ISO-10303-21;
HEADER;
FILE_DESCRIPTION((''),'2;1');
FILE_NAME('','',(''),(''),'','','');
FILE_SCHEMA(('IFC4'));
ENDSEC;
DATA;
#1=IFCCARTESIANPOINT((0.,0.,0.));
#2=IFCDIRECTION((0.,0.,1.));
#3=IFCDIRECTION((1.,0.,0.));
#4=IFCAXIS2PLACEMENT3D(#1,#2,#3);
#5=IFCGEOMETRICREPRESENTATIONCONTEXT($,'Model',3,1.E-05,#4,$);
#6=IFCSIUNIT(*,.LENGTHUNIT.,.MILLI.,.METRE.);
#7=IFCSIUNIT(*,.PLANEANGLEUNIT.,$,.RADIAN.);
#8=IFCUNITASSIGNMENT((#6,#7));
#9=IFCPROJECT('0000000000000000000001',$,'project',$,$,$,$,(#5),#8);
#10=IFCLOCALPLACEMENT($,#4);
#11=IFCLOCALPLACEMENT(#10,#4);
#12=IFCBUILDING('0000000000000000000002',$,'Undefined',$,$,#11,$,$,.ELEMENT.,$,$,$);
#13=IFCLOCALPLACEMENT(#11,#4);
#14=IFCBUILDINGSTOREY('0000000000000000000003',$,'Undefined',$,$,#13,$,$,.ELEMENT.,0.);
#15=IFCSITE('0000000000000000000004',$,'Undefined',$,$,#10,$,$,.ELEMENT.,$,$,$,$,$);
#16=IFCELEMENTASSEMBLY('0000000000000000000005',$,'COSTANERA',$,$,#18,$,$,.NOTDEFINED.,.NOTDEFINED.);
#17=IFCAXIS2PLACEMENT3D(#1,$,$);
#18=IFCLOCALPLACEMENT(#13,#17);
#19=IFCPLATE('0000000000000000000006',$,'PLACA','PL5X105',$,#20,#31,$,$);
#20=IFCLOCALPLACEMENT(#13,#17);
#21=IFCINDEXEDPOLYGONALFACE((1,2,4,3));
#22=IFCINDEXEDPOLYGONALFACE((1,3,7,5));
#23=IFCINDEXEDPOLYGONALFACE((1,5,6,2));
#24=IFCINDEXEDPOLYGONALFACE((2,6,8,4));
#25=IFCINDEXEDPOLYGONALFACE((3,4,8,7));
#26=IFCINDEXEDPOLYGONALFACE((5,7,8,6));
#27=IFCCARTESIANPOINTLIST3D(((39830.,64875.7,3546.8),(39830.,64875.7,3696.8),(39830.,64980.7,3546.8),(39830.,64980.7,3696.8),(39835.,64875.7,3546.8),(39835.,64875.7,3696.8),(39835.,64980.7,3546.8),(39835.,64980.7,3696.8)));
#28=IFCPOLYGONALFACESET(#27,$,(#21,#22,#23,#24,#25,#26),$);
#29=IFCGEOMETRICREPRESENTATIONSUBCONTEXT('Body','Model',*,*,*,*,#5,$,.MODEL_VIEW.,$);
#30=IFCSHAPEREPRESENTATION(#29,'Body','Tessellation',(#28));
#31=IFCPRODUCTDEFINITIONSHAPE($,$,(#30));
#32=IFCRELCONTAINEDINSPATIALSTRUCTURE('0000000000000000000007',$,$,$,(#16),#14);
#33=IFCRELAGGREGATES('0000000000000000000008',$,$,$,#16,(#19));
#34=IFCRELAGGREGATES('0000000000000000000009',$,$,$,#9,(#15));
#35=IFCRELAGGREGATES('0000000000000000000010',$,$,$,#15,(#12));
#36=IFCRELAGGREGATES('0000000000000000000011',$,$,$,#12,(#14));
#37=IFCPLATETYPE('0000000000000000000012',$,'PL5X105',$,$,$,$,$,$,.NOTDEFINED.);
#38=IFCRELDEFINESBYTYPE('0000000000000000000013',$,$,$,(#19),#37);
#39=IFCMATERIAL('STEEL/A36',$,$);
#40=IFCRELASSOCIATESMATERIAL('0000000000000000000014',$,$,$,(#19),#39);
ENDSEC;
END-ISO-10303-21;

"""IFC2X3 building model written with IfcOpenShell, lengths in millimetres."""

from ifc_helpers import new_model, si_unit, frame, origin_with_axes, place, context, subcontext, project, spatial, polyline, outline, extrude, material, type_object, element, aggregate, save


model = new_model("IFC2X3")

# Units and contexts
model_context = context("Model", 3, precision=1e-05, world=origin_with_axes())
body_context = subcontext(model_context, "Body", "Model", "MODEL_VIEW")
ifc_project = project(units=[si_unit("LENGTHUNIT", "METRE", prefix="MILLI"), si_unit("PLANEANGLEUNIT", "RADIAN")], contexts=[model_context])

# Site, building, storey
site_placement = place(None, origin_with_axes())
site = spatial("IfcSite", under=ifc_project, at=site_placement, Name="Undefined", CompositionType="ELEMENT")
building_placement = place(site_placement, origin_with_axes())
building = spatial("IfcBuilding", under=site, at=building_placement, Name="Undefined", CompositionType="ELEMENT")
storey_placement = place(building_placement, origin_with_axes())
storey = spatial("IfcBuildingStorey", under=building, at=storey_placement, Name="Undefined", CompositionType="ELEMENT", Elevation=0.0)

# Shared definitions
ifc_material_1 = material(Name="STEEL/A36")

# Element assembly
assembly_1_placement = place(storey_placement, origin_with_axes())
assembly_1 = element("IfcElementAssembly", 1, at=assembly_1_placement, inside=storey, Name="COSTANERA", AssemblyPlace="NOTDEFINED", PredefinedType="NOTDEFINED")

# Plate
plate_type_1 = type_object("IfcPlateType", Name="PL5X105", PredefinedType="NOTDEFINED")
plate_1_placement = place(assembly_1_placement, frame((39832.5, 64980.7, 3546.8), z_axis=(-1.0, 0.0, 0.0), x_axis=(0.0, -1.0, 0.0)))
plate_1 = element("IfcPlate", 2, at=plate_1_placement, type_object=plate_type_1, material=ifc_material_1, Name="PLACA", Description="PL5X105", context=body_context, shape_type="SweptSolid", body=[
    extrude(outline(polyline([(0.0, 0.0), (105.0, 0.0), (105.0, 150.0), (0.0, 150.0), (0.0, 0.0)])), frame((0.0, 0.0, -2.5), z_axis=(0.0, 0.0, 1.0), x_axis=(1.0, 0.0, 0.0)), (0.0, 0.0, 1.0), 5.0),
])

aggregate(assembly_1, [plate_1])

save(model, "model.ifc")
